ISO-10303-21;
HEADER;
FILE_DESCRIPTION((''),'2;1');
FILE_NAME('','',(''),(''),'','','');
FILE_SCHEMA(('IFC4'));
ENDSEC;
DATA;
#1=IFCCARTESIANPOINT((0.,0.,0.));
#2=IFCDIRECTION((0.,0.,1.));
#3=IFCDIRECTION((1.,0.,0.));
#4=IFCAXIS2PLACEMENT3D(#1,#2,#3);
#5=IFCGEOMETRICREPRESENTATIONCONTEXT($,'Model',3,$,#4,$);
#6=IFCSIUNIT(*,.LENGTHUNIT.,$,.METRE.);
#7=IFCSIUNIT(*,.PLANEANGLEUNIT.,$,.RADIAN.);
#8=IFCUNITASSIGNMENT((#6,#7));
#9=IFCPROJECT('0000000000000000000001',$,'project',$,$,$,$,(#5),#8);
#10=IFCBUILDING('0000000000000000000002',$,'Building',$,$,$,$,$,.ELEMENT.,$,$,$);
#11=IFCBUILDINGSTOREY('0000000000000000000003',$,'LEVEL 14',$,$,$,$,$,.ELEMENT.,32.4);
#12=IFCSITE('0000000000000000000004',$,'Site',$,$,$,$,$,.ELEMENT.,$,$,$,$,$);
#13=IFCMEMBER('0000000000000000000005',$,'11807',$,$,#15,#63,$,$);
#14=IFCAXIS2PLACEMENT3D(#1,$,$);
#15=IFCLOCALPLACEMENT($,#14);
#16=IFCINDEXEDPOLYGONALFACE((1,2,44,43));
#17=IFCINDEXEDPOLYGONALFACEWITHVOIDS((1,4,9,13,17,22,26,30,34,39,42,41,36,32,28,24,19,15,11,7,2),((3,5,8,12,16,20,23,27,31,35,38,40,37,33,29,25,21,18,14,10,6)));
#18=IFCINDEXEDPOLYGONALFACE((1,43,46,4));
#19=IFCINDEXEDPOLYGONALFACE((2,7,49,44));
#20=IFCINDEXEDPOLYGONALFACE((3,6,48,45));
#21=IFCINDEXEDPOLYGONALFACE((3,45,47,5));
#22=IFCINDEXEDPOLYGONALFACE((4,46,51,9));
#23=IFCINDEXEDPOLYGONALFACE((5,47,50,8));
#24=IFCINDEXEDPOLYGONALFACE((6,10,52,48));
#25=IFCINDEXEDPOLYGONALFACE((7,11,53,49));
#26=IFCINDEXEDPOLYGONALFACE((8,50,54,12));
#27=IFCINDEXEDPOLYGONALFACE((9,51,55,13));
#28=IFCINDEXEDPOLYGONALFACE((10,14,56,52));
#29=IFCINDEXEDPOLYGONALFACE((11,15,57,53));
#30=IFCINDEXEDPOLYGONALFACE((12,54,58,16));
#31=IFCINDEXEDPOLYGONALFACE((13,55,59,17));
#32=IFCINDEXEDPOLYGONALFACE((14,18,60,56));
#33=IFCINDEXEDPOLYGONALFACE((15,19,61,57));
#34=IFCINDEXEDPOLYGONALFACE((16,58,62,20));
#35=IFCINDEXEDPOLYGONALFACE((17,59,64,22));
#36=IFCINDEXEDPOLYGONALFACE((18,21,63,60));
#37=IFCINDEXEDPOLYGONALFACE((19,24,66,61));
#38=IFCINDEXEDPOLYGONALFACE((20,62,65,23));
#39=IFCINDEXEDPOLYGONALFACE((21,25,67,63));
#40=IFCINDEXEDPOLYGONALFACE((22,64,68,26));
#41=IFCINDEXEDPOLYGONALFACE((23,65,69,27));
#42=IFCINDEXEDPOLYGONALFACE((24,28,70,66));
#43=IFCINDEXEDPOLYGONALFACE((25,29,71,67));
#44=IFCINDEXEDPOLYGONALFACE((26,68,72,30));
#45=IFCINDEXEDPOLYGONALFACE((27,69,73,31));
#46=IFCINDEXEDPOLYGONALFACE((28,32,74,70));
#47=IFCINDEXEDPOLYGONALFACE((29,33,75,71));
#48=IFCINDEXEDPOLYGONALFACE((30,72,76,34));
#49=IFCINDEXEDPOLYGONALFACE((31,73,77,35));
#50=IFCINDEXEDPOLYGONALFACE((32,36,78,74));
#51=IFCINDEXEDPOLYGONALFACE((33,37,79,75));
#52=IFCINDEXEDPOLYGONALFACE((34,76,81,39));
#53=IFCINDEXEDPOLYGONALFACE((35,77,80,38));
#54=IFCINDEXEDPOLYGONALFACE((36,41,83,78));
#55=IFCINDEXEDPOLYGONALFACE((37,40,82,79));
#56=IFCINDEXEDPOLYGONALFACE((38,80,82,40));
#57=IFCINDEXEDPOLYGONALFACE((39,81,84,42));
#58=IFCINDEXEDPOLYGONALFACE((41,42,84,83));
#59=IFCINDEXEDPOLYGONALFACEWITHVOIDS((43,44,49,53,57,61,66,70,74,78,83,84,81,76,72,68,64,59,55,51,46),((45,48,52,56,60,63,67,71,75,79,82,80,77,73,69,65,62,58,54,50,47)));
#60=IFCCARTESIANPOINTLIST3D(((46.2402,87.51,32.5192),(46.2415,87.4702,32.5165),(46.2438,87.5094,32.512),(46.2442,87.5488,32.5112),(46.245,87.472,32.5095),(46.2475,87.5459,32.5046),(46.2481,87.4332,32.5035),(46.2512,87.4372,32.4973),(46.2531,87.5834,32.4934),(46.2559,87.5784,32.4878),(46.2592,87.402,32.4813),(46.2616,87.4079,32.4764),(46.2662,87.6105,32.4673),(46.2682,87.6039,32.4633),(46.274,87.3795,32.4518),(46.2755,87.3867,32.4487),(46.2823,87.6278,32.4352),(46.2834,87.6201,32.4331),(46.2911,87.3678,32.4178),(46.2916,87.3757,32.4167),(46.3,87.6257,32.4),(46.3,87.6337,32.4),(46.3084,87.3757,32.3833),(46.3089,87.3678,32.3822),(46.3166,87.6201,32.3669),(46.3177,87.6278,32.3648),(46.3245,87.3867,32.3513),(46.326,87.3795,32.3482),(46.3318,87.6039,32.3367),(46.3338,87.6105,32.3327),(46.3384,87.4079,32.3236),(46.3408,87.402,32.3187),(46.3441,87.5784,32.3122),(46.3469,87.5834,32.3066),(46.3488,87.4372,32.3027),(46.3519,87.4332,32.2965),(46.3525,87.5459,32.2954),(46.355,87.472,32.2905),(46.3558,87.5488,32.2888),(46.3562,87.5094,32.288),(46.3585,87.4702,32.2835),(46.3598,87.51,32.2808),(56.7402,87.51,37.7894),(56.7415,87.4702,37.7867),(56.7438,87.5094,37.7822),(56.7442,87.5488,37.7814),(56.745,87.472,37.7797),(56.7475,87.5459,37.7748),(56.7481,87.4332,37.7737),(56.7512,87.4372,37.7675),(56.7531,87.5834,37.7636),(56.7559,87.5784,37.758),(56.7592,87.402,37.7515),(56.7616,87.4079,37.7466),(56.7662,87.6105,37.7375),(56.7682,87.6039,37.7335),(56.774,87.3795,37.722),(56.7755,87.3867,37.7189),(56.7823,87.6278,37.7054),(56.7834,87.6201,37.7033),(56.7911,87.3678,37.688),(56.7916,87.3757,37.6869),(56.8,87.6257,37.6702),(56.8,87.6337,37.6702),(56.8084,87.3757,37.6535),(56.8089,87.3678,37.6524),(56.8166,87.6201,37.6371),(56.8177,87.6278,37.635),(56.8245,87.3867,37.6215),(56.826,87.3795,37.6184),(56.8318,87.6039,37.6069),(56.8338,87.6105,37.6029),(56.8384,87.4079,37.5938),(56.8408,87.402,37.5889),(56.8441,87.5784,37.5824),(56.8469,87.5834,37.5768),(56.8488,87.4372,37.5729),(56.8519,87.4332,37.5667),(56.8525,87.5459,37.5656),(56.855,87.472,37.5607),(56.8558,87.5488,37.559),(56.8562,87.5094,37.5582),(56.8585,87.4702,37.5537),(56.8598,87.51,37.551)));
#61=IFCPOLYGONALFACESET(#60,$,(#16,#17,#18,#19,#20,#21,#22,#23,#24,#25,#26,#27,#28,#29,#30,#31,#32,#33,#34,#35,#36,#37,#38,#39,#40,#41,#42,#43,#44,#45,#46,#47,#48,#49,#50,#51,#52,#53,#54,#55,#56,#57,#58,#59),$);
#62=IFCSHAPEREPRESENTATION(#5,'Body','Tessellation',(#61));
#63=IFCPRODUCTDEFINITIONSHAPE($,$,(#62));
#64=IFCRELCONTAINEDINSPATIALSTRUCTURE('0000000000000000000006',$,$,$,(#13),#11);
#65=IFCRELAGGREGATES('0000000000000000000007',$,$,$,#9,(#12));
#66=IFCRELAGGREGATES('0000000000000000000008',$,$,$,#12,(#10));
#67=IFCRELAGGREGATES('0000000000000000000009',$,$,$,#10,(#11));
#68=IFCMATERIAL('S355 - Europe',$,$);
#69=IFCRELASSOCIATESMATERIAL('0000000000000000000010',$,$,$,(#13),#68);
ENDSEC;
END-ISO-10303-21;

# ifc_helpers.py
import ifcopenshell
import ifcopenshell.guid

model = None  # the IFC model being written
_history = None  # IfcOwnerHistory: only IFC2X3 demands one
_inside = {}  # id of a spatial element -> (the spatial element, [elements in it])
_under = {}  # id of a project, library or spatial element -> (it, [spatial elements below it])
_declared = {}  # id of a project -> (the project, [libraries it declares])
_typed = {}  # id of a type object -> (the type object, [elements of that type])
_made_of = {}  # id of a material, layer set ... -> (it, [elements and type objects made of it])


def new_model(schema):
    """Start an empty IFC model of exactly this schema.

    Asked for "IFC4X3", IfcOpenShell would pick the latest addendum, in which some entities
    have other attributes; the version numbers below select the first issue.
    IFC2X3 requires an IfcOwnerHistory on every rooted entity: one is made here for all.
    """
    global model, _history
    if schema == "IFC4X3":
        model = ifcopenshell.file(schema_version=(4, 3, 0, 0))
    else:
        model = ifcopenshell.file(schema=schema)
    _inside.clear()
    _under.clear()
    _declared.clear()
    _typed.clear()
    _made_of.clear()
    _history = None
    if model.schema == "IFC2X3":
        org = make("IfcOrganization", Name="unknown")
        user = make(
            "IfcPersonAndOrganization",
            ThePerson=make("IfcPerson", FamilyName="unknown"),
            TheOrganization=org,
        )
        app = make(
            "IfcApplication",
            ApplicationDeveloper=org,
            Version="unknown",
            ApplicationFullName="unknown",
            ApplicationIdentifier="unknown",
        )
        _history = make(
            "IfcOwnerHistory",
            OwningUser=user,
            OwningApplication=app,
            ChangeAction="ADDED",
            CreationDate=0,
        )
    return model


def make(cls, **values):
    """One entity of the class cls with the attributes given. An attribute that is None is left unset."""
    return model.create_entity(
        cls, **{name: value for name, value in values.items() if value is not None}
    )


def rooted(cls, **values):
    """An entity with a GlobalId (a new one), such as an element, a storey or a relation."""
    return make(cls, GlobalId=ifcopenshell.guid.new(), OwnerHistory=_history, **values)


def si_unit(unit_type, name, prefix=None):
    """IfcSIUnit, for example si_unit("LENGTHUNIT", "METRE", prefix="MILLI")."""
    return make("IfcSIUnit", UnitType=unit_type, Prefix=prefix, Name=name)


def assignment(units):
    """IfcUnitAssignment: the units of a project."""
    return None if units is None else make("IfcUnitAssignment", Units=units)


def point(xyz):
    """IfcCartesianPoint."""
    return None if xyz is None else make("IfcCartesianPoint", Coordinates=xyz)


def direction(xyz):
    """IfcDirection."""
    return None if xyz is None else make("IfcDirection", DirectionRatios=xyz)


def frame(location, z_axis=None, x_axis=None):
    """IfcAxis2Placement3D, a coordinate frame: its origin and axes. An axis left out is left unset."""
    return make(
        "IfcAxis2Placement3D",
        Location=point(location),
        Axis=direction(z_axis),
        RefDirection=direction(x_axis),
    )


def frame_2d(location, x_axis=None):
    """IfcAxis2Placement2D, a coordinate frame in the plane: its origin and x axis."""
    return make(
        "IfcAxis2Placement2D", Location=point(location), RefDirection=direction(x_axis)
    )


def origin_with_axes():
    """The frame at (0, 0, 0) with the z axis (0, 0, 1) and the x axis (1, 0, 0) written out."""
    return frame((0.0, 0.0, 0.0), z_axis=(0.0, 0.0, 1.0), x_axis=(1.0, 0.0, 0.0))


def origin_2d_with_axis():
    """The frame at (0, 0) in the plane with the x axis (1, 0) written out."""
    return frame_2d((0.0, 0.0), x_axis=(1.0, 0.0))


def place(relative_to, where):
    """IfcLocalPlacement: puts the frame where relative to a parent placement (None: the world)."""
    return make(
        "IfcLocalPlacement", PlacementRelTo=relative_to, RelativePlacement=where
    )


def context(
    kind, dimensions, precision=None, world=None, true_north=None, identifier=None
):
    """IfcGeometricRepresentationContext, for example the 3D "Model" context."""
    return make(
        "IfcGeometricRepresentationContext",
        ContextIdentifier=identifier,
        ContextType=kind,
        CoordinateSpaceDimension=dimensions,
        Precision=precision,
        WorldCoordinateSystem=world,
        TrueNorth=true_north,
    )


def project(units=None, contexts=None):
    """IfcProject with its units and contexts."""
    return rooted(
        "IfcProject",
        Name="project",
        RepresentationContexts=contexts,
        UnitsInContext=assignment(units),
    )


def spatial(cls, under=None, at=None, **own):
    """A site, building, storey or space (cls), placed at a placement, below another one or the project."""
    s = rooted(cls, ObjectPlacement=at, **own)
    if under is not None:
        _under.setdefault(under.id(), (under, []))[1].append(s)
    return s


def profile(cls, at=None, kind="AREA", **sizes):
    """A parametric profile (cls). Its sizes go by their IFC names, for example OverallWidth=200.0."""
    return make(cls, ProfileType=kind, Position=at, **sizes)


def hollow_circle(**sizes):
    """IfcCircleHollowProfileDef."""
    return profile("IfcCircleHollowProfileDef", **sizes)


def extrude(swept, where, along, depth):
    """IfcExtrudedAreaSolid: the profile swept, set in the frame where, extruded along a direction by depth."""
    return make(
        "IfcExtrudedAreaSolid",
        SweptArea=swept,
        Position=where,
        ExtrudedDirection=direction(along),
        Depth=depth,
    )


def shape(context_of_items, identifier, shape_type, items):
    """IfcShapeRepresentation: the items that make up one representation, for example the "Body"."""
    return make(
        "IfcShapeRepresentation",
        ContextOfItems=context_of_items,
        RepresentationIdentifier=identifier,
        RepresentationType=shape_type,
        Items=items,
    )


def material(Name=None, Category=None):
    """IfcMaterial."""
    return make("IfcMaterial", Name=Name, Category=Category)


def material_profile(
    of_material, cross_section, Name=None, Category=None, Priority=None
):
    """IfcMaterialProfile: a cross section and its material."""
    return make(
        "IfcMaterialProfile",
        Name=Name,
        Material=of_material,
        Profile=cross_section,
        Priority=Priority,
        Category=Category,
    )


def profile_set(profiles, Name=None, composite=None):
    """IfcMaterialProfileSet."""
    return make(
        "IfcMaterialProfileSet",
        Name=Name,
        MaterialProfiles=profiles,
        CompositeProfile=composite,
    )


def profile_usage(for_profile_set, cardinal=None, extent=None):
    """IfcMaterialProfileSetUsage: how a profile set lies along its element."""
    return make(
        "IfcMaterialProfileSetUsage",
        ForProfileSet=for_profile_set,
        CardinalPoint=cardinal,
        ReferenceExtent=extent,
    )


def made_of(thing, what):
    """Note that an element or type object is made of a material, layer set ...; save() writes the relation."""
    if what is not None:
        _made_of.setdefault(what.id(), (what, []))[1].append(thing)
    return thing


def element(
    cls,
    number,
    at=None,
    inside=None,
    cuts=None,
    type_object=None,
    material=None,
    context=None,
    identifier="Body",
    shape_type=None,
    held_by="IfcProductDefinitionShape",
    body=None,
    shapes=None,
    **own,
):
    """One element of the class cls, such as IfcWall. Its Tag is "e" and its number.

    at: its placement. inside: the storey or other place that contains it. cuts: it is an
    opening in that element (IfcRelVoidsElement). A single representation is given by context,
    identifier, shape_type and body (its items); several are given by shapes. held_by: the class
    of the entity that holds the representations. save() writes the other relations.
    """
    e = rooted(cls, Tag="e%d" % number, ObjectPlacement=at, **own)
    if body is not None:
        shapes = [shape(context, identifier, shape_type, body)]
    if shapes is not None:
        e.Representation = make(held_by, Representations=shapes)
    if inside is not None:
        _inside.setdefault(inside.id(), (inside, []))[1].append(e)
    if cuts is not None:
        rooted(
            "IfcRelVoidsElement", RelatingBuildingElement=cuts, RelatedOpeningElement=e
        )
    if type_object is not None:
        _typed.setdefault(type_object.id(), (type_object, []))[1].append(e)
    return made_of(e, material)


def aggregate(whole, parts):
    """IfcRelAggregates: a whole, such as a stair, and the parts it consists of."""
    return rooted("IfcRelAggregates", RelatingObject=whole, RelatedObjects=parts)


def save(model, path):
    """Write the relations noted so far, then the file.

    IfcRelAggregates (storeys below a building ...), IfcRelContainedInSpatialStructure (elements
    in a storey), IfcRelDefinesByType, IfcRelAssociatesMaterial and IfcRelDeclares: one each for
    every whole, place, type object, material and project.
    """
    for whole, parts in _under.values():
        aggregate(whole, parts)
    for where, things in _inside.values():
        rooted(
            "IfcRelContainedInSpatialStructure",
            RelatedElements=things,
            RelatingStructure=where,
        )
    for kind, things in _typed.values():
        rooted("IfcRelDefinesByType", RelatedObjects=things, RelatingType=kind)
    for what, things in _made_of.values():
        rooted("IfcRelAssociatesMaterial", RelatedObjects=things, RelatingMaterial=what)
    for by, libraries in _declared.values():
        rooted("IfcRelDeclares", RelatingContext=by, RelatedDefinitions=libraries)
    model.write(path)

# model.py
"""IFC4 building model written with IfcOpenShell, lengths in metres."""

from ifc_helpers import new_model, si_unit, frame, origin_with_axes, origin_2d_with_axis, place, context, project, spatial, hollow_circle, extrude, material, material_profile, profile_set, profile_usage, element, save


model = new_model("IFC4")

# Units and contexts
model_context = context("Model", 3, world=origin_with_axes())
ifc_project = project(units=[si_unit("LENGTHUNIT", "METRE"), si_unit("PLANEANGLEUNIT", "RADIAN")], contexts=[model_context])

# Site, building, storey
site = spatial("IfcSite", under=ifc_project, Name="Site", CompositionType="ELEMENT")
building = spatial("IfcBuilding", under=site, Name="Building", CompositionType="ELEMENT")
storey = spatial("IfcBuildingStorey", under=building, Name="LEVEL 14", CompositionType="ELEMENT", Elevation=32.4)

# Shared definitions
ifc_material = material(Name="S355 - Europe")

# Member
ifc_material_profile_1 = material_profile(ifc_material, hollow_circle(Radius=0.1337, WallThickness=0.008, at=origin_2d_with_axis()))
ifc_profile_set_1 = profile_set([ifc_material_profile_1])
ifc_profile_usage_1 = profile_usage(ifc_profile_set_1, cardinal=10)
member_1_placement = place(None, frame((46.3, 87.5, 32.4), z_axis=(0.893738, 0.0, 0.448589), x_axis=(0.0, 1.0, 0.0)))
element("IfcMember", 1, at=member_1_placement, inside=storey, material=ifc_profile_usage_1, Name="11807", context=model_context, shape_type="SweptSolid", body=[
    extrude(hollow_circle(Radius=0.1337, WallThickness=0.008, at=origin_2d_with_axis()), origin_with_axes(), (0.0, 0.0, 1.0), 11.7484),
])

save(model, "model.ifc")
